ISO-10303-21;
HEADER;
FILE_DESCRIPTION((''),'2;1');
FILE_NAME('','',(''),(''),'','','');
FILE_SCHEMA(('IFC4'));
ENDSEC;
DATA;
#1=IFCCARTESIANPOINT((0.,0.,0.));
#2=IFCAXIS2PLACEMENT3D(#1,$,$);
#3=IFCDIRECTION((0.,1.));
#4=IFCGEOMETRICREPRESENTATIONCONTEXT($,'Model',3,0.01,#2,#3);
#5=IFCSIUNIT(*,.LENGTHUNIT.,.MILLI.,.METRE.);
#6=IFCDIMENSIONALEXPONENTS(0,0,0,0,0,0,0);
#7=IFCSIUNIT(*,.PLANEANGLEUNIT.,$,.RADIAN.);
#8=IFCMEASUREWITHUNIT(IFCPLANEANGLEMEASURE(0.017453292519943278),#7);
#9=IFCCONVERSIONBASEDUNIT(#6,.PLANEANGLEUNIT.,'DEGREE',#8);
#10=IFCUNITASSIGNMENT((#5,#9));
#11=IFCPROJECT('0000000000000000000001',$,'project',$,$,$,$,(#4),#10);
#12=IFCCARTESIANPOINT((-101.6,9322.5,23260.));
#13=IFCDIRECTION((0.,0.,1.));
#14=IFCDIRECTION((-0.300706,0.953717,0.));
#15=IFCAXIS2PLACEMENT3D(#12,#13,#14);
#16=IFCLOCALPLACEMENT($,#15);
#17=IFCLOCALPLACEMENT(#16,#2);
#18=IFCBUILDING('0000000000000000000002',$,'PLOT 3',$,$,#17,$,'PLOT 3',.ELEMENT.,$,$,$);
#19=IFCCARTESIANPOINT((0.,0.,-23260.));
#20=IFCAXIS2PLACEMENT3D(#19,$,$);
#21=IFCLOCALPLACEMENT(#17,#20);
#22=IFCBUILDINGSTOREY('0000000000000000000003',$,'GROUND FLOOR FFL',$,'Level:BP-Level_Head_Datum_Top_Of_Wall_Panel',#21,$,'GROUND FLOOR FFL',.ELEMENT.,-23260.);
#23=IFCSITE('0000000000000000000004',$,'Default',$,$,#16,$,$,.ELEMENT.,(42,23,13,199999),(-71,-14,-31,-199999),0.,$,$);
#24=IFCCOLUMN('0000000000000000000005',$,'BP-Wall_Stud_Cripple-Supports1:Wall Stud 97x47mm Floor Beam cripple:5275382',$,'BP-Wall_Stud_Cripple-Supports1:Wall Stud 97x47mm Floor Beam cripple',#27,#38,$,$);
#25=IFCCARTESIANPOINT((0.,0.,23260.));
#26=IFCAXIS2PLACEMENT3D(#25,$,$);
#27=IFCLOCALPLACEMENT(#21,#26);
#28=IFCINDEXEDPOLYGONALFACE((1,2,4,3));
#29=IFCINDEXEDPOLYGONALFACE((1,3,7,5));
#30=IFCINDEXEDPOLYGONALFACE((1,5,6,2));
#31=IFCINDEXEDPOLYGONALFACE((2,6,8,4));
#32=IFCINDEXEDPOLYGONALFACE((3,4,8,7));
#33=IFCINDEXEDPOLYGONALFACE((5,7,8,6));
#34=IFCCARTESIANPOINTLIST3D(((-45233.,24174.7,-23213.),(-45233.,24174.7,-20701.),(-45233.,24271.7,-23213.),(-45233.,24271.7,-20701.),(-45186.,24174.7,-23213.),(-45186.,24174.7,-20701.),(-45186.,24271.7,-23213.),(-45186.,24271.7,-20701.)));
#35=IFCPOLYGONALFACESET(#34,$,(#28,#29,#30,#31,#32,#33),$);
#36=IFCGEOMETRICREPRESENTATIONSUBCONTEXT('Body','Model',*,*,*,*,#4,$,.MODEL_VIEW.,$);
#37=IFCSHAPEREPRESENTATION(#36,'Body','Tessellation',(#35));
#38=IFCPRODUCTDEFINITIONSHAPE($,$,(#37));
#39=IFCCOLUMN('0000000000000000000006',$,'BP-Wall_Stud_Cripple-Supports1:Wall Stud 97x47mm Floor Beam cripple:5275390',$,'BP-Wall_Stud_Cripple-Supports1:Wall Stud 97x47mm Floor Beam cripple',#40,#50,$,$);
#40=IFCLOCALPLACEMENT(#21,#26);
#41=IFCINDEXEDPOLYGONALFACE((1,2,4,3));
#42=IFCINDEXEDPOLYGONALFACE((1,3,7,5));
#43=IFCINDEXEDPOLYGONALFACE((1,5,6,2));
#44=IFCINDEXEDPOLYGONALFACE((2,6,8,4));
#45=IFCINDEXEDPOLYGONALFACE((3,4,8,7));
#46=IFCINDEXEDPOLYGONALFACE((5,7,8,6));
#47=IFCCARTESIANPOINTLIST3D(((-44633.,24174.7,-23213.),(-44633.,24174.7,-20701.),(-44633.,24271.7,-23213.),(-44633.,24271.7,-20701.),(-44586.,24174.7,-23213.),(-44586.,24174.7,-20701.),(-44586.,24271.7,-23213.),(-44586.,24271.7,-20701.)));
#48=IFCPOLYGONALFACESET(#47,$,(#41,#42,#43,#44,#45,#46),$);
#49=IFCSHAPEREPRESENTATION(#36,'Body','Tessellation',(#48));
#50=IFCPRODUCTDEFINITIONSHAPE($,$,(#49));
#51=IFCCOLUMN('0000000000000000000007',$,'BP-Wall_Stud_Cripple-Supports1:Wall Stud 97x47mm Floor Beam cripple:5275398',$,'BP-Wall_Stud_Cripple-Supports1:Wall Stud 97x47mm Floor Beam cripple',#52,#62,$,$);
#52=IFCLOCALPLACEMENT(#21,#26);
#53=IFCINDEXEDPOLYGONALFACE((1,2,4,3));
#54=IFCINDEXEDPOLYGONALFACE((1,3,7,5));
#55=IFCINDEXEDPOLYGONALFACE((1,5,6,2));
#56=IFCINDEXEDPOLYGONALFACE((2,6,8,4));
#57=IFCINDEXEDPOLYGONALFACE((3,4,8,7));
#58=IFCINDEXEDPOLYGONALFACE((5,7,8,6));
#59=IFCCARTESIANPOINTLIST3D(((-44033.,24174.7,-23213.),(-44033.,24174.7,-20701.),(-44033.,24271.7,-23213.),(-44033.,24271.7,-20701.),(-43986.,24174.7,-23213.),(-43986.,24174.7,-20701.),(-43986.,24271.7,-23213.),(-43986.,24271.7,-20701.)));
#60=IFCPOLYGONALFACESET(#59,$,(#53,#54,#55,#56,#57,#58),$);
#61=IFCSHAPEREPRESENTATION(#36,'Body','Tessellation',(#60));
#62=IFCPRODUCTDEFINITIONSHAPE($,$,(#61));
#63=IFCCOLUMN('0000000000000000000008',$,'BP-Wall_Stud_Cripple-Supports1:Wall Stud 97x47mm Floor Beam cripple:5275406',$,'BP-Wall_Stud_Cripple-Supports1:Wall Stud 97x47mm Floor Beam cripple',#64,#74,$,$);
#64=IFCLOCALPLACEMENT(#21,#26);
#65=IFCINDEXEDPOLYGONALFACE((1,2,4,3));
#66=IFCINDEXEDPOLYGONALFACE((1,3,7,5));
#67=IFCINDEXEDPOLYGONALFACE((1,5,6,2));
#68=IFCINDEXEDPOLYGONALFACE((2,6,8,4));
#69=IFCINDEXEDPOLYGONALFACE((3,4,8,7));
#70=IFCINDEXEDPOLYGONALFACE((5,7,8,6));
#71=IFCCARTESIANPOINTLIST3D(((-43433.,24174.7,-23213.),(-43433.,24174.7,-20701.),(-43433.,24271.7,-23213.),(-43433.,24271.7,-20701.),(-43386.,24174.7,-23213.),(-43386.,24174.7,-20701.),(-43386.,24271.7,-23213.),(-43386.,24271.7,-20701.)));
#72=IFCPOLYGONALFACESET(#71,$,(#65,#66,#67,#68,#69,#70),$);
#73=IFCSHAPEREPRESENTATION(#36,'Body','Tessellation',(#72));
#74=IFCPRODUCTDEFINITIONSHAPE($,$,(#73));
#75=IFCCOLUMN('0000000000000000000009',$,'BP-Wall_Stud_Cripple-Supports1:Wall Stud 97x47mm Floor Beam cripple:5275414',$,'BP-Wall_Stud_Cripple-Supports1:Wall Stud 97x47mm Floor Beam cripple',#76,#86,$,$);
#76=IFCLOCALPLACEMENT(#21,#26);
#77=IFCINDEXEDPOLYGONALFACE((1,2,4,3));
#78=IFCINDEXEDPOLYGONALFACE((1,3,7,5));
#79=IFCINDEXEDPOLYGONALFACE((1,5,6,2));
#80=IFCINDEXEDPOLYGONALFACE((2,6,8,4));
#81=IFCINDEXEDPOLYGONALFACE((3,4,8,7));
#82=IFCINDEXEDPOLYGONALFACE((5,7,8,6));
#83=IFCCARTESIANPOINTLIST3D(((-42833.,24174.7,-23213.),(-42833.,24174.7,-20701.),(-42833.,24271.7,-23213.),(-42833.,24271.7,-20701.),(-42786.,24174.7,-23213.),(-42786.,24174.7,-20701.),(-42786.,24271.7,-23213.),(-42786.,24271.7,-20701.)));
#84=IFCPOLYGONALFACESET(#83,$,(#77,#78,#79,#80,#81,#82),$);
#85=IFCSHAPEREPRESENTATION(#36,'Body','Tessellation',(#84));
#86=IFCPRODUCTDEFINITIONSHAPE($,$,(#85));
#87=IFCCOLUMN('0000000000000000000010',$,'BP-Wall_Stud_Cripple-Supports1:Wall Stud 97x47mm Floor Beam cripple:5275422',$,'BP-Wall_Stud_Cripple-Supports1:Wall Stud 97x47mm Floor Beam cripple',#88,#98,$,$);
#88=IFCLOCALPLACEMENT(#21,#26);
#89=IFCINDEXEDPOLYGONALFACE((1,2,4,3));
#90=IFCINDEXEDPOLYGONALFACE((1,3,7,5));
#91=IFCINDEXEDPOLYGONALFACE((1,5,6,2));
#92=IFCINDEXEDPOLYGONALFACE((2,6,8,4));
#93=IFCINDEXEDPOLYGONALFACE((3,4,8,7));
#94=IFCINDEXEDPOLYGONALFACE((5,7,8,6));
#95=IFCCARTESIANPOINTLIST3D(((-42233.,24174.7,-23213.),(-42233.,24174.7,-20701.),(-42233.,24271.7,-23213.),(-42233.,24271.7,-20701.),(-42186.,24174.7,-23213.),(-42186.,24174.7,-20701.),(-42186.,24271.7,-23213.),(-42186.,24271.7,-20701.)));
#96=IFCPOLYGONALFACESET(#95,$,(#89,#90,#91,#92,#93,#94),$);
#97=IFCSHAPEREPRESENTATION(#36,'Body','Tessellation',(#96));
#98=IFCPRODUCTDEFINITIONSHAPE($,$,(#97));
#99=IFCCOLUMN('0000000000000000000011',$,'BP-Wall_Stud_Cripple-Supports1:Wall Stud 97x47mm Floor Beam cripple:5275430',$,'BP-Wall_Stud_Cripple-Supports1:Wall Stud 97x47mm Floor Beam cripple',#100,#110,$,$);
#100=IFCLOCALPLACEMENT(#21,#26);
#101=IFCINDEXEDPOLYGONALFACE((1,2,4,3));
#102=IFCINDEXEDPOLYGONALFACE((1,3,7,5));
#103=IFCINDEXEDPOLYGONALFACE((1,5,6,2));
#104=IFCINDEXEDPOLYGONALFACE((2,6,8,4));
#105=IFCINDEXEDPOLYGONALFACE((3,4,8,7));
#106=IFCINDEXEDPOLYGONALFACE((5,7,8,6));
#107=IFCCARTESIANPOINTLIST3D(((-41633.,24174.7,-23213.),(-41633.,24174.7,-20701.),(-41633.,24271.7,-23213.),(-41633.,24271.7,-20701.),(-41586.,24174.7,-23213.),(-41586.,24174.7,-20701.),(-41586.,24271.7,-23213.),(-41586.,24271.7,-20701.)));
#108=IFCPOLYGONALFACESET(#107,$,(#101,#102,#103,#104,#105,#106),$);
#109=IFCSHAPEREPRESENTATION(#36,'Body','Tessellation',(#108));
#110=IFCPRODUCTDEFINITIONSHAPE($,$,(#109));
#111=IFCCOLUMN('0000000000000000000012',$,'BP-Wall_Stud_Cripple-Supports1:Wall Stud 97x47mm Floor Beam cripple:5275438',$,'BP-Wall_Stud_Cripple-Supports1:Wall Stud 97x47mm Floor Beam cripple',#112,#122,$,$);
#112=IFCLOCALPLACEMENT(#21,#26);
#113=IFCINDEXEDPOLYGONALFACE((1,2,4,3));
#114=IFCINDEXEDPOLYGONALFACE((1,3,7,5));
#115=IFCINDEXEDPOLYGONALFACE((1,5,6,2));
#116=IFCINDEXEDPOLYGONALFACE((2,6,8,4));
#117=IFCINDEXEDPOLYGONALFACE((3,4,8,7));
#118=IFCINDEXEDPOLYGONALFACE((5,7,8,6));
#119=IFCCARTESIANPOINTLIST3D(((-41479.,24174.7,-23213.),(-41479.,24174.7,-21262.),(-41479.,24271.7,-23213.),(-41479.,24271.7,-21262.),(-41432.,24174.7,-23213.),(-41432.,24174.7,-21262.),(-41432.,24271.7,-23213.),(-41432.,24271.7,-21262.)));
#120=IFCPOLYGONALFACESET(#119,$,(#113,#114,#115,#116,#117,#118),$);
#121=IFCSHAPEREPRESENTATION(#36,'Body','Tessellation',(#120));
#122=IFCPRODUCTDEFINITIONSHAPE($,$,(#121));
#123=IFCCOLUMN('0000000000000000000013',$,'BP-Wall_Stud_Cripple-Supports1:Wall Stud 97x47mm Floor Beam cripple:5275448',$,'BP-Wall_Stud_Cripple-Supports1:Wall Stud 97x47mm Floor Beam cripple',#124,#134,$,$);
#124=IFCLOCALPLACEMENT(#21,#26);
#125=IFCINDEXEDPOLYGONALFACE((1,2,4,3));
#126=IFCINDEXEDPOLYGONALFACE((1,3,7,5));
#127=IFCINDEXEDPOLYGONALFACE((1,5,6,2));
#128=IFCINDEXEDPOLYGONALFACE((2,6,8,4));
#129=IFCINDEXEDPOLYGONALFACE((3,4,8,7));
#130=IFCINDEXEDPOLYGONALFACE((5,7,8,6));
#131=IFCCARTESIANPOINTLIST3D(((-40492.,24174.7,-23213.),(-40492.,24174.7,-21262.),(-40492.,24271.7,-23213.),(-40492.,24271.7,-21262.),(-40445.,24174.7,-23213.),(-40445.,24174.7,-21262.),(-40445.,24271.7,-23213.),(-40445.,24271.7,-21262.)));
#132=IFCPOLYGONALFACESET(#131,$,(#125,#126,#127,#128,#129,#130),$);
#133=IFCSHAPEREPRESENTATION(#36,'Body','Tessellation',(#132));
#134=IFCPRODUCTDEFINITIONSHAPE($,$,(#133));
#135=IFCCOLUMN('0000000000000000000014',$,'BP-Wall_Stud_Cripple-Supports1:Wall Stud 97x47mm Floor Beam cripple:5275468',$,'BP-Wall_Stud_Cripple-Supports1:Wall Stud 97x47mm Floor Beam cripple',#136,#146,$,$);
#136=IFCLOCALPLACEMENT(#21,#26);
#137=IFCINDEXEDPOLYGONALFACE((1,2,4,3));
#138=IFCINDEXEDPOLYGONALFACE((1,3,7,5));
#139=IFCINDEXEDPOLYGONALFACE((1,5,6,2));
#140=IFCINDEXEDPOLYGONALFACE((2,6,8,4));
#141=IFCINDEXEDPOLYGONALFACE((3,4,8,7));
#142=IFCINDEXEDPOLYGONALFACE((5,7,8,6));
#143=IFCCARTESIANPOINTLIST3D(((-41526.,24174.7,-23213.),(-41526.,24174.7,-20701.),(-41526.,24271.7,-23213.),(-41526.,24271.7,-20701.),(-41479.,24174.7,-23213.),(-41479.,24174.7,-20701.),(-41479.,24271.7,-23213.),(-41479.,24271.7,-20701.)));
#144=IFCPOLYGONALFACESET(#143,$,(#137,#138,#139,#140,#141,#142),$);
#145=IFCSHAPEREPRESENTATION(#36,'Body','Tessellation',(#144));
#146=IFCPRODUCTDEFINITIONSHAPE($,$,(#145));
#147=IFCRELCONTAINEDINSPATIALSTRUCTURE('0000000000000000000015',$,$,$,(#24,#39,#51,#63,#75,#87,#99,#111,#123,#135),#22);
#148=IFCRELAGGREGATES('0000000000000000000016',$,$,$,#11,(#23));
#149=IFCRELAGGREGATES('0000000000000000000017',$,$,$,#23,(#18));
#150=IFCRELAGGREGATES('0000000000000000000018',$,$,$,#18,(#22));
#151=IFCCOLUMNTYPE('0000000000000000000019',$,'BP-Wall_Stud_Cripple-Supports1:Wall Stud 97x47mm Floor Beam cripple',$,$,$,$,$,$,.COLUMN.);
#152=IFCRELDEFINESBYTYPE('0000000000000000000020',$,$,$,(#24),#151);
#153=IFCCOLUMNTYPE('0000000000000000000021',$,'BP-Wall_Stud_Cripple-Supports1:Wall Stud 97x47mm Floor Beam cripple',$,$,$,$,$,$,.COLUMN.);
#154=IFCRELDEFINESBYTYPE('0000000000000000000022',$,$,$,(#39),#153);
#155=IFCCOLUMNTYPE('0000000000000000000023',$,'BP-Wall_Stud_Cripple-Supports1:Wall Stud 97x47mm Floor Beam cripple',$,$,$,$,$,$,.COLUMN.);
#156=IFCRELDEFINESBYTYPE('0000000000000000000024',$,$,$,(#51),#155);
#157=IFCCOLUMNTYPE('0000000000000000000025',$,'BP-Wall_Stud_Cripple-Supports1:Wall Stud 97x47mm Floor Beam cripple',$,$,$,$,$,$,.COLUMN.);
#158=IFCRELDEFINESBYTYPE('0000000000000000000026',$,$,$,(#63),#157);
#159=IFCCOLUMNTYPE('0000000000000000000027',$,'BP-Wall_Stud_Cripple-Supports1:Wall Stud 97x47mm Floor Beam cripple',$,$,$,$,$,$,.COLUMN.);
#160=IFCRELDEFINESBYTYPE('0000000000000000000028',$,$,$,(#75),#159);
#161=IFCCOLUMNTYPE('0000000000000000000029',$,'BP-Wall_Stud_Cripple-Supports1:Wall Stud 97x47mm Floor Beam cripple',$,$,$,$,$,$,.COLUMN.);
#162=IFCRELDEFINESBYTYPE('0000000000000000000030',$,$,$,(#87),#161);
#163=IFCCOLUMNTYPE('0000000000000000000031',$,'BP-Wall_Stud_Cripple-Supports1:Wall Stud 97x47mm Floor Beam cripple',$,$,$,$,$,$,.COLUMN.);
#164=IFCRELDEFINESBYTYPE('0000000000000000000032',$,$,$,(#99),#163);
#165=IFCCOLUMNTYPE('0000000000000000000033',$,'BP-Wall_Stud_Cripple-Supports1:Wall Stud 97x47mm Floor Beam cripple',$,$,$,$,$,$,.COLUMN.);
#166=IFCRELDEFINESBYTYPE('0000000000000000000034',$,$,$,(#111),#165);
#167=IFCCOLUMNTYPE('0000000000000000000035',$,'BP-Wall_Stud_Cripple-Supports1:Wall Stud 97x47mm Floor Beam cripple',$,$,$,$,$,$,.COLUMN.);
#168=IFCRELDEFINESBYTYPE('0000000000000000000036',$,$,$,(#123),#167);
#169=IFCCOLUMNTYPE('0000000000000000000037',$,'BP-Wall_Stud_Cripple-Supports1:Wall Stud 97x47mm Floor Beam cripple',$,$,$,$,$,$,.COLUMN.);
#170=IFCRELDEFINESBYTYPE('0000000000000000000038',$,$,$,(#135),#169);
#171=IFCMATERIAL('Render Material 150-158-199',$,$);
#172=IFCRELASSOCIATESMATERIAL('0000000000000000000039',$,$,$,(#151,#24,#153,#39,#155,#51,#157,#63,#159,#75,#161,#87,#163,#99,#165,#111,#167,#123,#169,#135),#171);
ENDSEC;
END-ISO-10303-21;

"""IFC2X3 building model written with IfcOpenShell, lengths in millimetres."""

from ifc_helpers import new_model, entity, si_unit, converted_unit, direction, frame, frame_2d, origin, place, context, subcontext, project, spatial, rectangle, extrude, source, transform, mapped, material, type_object, type_shapes, element, save


model = new_model("IFC2X3")

# Units and contexts
model_context = context("Model", 3, precision=0.01, world=origin(), true_north=direction((0.0, 1.0)))
body_context = subcontext(model_context, "Body", "Model", "MODEL_VIEW")
ifc_project = project(units=[si_unit("LENGTHUNIT", "METRE", prefix="MILLI"), converted_unit("PLANEANGLEUNIT", "DEGREE", entity("IfcPlaneAngleMeasure", 0.017453292519943278), si_unit("PLANEANGLEUNIT", "RADIAN"), dimensions=[0, 0, 0, 0, 0, 0, 0])], contexts=[model_context])

# Site, building, storey
site_placement = place(None, frame((-101.6, 9322.5, 23260.0), z_axis=(0.0, 0.0, 1.0), x_axis=(-0.300706, 0.953717, 0.0)))
site = spatial("IfcSite", under=ifc_project, at=site_placement, Name="Default", CompositionType="ELEMENT", RefLatitude=(42, 23, 13, 199999), RefLongitude=(-71, -14, -31, -199999), RefElevation=0.0)
building_placement = place(site_placement, origin())
building = spatial("IfcBuilding", under=site, at=building_placement, Name="PLOT 3", LongName="PLOT 3", CompositionType="ELEMENT")
storey_placement = place(building_placement, frame((0.0, 0.0, -23260.0)))
storey = spatial("IfcBuildingStorey", under=building, at=storey_placement, Name="GROUND FLOOR FFL", ObjectType="Level:BP-Level_Head_Datum_Top_Of_Wall_Panel", LongName="GROUND FLOOR FFL", CompositionType="ELEMENT", Elevation=-23260.0)

# Columns
ifc_material_1 = material(Name="Render Material 150-158-199")
column_type_1 = type_object("IfcColumnType", Name="BP-Wall_Stud_Cripple-Supports1:Wall Stud 97x47mm Floor Beam cripple", PredefinedType="COLUMN", material=ifc_material_1)
shared_shape_1 = source(origin(), body_context, "Body", "SweptSolid", [
    extrude(rectangle(XDim=97.0, YDim=47.0, at=frame_2d((0.0, 0.0), x_axis=(1.0, 0.0))), frame((-45209.5, 24223.2, -23213.0), z_axis=(0.0, 0.0, 1.0), x_axis=(0.0, -1.0, 0.0)), (0.0, 0.0, 1.0), 2512.0),
])
type_shapes(column_type_1, [shared_shape_1])
column_1_placement = place(storey_placement, frame((0.0, 0.0, 23260.0)))
element("IfcColumn", 1, at=column_1_placement, inside=storey, type_object=column_type_1, material=ifc_material_1, Name="BP-Wall_Stud_Cripple-Supports1:Wall Stud 97x47mm Floor Beam cripple:5275382", ObjectType="BP-Wall_Stud_Cripple-Supports1:Wall Stud 97x47mm Floor Beam cripple", context=body_context, shape_type="MappedRepresentation", body=[
    mapped(shared_shape_1, transform((0.0, 0.0, 0.0), scale=1.0)),
])
column_type_2 = type_object("IfcColumnType", Name="BP-Wall_Stud_Cripple-Supports1:Wall Stud 97x47mm Floor Beam cripple", PredefinedType="COLUMN", material=ifc_material_1)
shared_shape_2 = source(origin(), body_context, "Body", "SweptSolid", [
    extrude(rectangle(XDim=97.0, YDim=47.0, at=frame_2d((0.0, 0.0), x_axis=(1.0, 0.0))), frame((-44609.5, 24223.2, -23213.0), z_axis=(0.0, 0.0, 1.0), x_axis=(0.0, -1.0, 0.0)), (0.0, 0.0, 1.0), 2512.0),
])
type_shapes(column_type_2, [shared_shape_2])
column_2_placement = place(storey_placement, frame((0.0, 0.0, 23260.0)))
element("IfcColumn", 2, at=column_2_placement, inside=storey, type_object=column_type_2, material=ifc_material_1, Name="BP-Wall_Stud_Cripple-Supports1:Wall Stud 97x47mm Floor Beam cripple:5275390", ObjectType="BP-Wall_Stud_Cripple-Supports1:Wall Stud 97x47mm Floor Beam cripple", context=body_context, shape_type="MappedRepresentation", body=[
    mapped(shared_shape_2, transform((0.0, 0.0, 0.0), scale=1.0)),
])
column_type_3 = type_object("IfcColumnType", Name="BP-Wall_Stud_Cripple-Supports1:Wall Stud 97x47mm Floor Beam cripple", PredefinedType="COLUMN", material=ifc_material_1)
shared_shape_3 = source(origin(), body_context, "Body", "SweptSolid", [
    extrude(rectangle(XDim=97.0, YDim=47.0, at=frame_2d((0.0, 0.0), x_axis=(1.0, 0.0))), frame((-44009.5, 24223.2, -23213.0), z_axis=(0.0, 0.0, 1.0), x_axis=(0.0, -1.0, 0.0)), (0.0, 0.0, 1.0), 2512.0),
])
type_shapes(column_type_3, [shared_shape_3])
column_3_placement = place(storey_placement, frame((0.0, 0.0, 23260.0)))
element("IfcColumn", 3, at=column_3_placement, inside=storey, type_object=column_type_3, material=ifc_material_1, Name="BP-Wall_Stud_Cripple-Supports1:Wall Stud 97x47mm Floor Beam cripple:5275398", ObjectType="BP-Wall_Stud_Cripple-Supports1:Wall Stud 97x47mm Floor Beam cripple", context=body_context, shape_type="MappedRepresentation", body=[
    mapped(shared_shape_3, transform((0.0, 0.0, 0.0), scale=1.0)),
])
column_type_4 = type_object("IfcColumnType", Name="BP-Wall_Stud_Cripple-Supports1:Wall Stud 97x47mm Floor Beam cripple", PredefinedType="COLUMN", material=ifc_material_1)
shared_shape_4 = source(origin(), body_context, "Body", "SweptSolid", [
    extrude(rectangle(XDim=97.0, YDim=47.0, at=frame_2d((0.0, 0.0), x_axis=(1.0, 0.0))), frame((-43409.5, 24223.2, -23213.0), z_axis=(0.0, 0.0, 1.0), x_axis=(0.0, -1.0, 0.0)), (0.0, 0.0, 1.0), 2512.0),
])
type_shapes(column_type_4, [shared_shape_4])
column_4_placement = place(storey_placement, frame((0.0, 0.0, 23260.0)))
element("IfcColumn", 4, at=column_4_placement, inside=storey, type_object=column_type_4, material=ifc_material_1, Name="BP-Wall_Stud_Cripple-Supports1:Wall Stud 97x47mm Floor Beam cripple:5275406", ObjectType="BP-Wall_Stud_Cripple-Supports1:Wall Stud 97x47mm Floor Beam cripple", context=body_context, shape_type="MappedRepresentation", body=[
    mapped(shared_shape_4, transform((0.0, 0.0, 0.0), scale=1.0)),
])
column_type_5 = type_object("IfcColumnType", Name="BP-Wall_Stud_Cripple-Supports1:Wall Stud 97x47mm Floor Beam cripple", PredefinedType="COLUMN", material=ifc_material_1)
shared_shape_5 = source(origin(), body_context, "Body", "SweptSolid", [
    extrude(rectangle(XDim=97.0, YDim=47.0, at=frame_2d((0.0, 0.0), x_axis=(1.0, 0.0))), frame((-42809.5, 24223.2, -23213.0), z_axis=(0.0, 0.0, 1.0), x_axis=(0.0, -1.0, 0.0)), (0.0, 0.0, 1.0), 2512.0),
])
type_shapes(column_type_5, [shared_shape_5])
column_5_placement = place(storey_placement, frame((0.0, 0.0, 23260.0)))
element("IfcColumn", 5, at=column_5_placement, inside=storey, type_object=column_type_5, material=ifc_material_1, Name="BP-Wall_Stud_Cripple-Supports1:Wall Stud 97x47mm Floor Beam cripple:5275414", ObjectType="BP-Wall_Stud_Cripple-Supports1:Wall Stud 97x47mm Floor Beam cripple", context=body_context, shape_type="MappedRepresentation", body=[
    mapped(shared_shape_5, transform((0.0, 0.0, 0.0), scale=1.0)),
])
column_type_6 = type_object("IfcColumnType", Name="BP-Wall_Stud_Cripple-Supports1:Wall Stud 97x47mm Floor Beam cripple", PredefinedType="COLUMN", material=ifc_material_1)
shared_shape_6 = source(origin(), body_context, "Body", "SweptSolid", [
    extrude(rectangle(XDim=97.0, YDim=47.0, at=frame_2d((0.0, 0.0), x_axis=(1.0, 0.0))), frame((-42209.5, 24223.2, -23213.0), z_axis=(0.0, 0.0, 1.0), x_axis=(0.0, -1.0, 0.0)), (0.0, 0.0, 1.0), 2512.0),
])
type_shapes(column_type_6, [shared_shape_6])
column_6_placement = place(storey_placement, frame((0.0, 0.0, 23260.0)))
element("IfcColumn", 6, at=column_6_placement, inside=storey, type_object=column_type_6, material=ifc_material_1, Name="BP-Wall_Stud_Cripple-Supports1:Wall Stud 97x47mm Floor Beam cripple:5275422", ObjectType="BP-Wall_Stud_Cripple-Supports1:Wall Stud 97x47mm Floor Beam cripple", context=body_context, shape_type="MappedRepresentation", body=[
    mapped(shared_shape_6, transform((0.0, 0.0, 0.0), scale=1.0)),
])
column_type_7 = type_object("IfcColumnType", Name="BP-Wall_Stud_Cripple-Supports1:Wall Stud 97x47mm Floor Beam cripple", PredefinedType="COLUMN", material=ifc_material_1)
shared_shape_7 = source(origin(), body_context, "Body", "SweptSolid", [
    extrude(rectangle(XDim=97.0, YDim=47.0, at=frame_2d((0.0, 0.0), x_axis=(1.0, 0.0))), frame((-41609.5, 24223.2, -23213.0), z_axis=(0.0, 0.0, 1.0), x_axis=(0.0, -1.0, 0.0)), (0.0, 0.0, 1.0), 2512.0),
])
type_shapes(column_type_7, [shared_shape_7])
column_7_placement = place(storey_placement, frame((0.0, 0.0, 23260.0)))
element("IfcColumn", 7, at=column_7_placement, inside=storey, type_object=column_type_7, material=ifc_material_1, Name="BP-Wall_Stud_Cripple-Supports1:Wall Stud 97x47mm Floor Beam cripple:5275430", ObjectType="BP-Wall_Stud_Cripple-Supports1:Wall Stud 97x47mm Floor Beam cripple", context=body_context, shape_type="MappedRepresentation", body=[
    mapped(shared_shape_7, transform((0.0, 0.0, 0.0), scale=1.0)),
])
column_type_8 = type_object("IfcColumnType", Name="BP-Wall_Stud_Cripple-Supports1:Wall Stud 97x47mm Floor Beam cripple", PredefinedType="COLUMN", material=ifc_material_1)
shared_shape_8 = source(origin(), body_context, "Body", "SweptSolid", [
    extrude(rectangle(XDim=97.0, YDim=47.0, at=frame_2d((0.0, 0.0), x_axis=(1.0, 0.0))), frame((-41455.5, 24223.2, -23213.0), z_axis=(0.0, 0.0, 1.0), x_axis=(0.0, -1.0, 0.0)), (0.0, 0.0, 1.0), 1951.0),
])
type_shapes(column_type_8, [shared_shape_8])
column_8_placement = place(storey_placement, frame((0.0, 0.0, 23260.0)))
element("IfcColumn", 8, at=column_8_placement, inside=storey, type_object=column_type_8, material=ifc_material_1, Name="BP-Wall_Stud_Cripple-Supports1:Wall Stud 97x47mm Floor Beam cripple:5275438", ObjectType="BP-Wall_Stud_Cripple-Supports1:Wall Stud 97x47mm Floor Beam cripple", context=body_context, shape_type="MappedRepresentation", body=[
    mapped(shared_shape_8, transform((0.0, 0.0, 0.0), scale=1.0)),
])
column_type_9 = type_object("IfcColumnType", Name="BP-Wall_Stud_Cripple-Supports1:Wall Stud 97x47mm Floor Beam cripple", PredefinedType="COLUMN", material=ifc_material_1)
shared_shape_9 = source(origin(), body_context, "Body", "SweptSolid", [
    extrude(rectangle(XDim=97.0, YDim=47.0, at=frame_2d((0.0, 0.0), x_axis=(1.0, 0.0))), frame((-40468.5, 24223.2, -23213.0), z_axis=(0.0, 0.0, 1.0), x_axis=(0.0, -1.0, 0.0)), (0.0, 0.0, 1.0), 1951.0),
])
type_shapes(column_type_9, [shared_shape_9])
column_9_placement = place(storey_placement, frame((0.0, 0.0, 23260.0)))
element("IfcColumn", 9, at=column_9_placement, inside=storey, type_object=column_type_9, material=ifc_material_1, Name="BP-Wall_Stud_Cripple-Supports1:Wall Stud 97x47mm Floor Beam cripple:5275448", ObjectType="BP-Wall_Stud_Cripple-Supports1:Wall Stud 97x47mm Floor Beam cripple", context=body_context, shape_type="MappedRepresentation", body=[
    mapped(shared_shape_9, transform((0.0, 0.0, 0.0), scale=1.0)),
])
column_type_10 = type_object("IfcColumnType", Name="BP-Wall_Stud_Cripple-Supports1:Wall Stud 97x47mm Floor Beam cripple", PredefinedType="COLUMN", material=ifc_material_1)
shared_shape_10 = source(origin(), body_context, "Body", "SweptSolid", [
    extrude(rectangle(XDim=97.0, YDim=47.0, at=frame_2d((0.0, 0.0), x_axis=(1.0, 0.0))), frame((-41502.5, 24223.2, -23213.0), z_axis=(0.0, 0.0, 1.0), x_axis=(0.0, -1.0, 0.0)), (0.0, 0.0, 1.0), 2512.0),
])
type_shapes(column_type_10, [shared_shape_10])
column_10_placement = place(storey_placement, frame((0.0, 0.0, 23260.0)))
element("IfcColumn", 10, at=column_10_placement, inside=storey, type_object=column_type_10, material=ifc_material_1, Name="BP-Wall_Stud_Cripple-Supports1:Wall Stud 97x47mm Floor Beam cripple:5275468", ObjectType="BP-Wall_Stud_Cripple-Supports1:Wall Stud 97x47mm Floor Beam cripple", context=body_context, shape_type="MappedRepresentation", body=[
    mapped(shared_shape_10, transform((0.0, 0.0, 0.0), scale=1.0)),
])

save(model, "model.ifc")
